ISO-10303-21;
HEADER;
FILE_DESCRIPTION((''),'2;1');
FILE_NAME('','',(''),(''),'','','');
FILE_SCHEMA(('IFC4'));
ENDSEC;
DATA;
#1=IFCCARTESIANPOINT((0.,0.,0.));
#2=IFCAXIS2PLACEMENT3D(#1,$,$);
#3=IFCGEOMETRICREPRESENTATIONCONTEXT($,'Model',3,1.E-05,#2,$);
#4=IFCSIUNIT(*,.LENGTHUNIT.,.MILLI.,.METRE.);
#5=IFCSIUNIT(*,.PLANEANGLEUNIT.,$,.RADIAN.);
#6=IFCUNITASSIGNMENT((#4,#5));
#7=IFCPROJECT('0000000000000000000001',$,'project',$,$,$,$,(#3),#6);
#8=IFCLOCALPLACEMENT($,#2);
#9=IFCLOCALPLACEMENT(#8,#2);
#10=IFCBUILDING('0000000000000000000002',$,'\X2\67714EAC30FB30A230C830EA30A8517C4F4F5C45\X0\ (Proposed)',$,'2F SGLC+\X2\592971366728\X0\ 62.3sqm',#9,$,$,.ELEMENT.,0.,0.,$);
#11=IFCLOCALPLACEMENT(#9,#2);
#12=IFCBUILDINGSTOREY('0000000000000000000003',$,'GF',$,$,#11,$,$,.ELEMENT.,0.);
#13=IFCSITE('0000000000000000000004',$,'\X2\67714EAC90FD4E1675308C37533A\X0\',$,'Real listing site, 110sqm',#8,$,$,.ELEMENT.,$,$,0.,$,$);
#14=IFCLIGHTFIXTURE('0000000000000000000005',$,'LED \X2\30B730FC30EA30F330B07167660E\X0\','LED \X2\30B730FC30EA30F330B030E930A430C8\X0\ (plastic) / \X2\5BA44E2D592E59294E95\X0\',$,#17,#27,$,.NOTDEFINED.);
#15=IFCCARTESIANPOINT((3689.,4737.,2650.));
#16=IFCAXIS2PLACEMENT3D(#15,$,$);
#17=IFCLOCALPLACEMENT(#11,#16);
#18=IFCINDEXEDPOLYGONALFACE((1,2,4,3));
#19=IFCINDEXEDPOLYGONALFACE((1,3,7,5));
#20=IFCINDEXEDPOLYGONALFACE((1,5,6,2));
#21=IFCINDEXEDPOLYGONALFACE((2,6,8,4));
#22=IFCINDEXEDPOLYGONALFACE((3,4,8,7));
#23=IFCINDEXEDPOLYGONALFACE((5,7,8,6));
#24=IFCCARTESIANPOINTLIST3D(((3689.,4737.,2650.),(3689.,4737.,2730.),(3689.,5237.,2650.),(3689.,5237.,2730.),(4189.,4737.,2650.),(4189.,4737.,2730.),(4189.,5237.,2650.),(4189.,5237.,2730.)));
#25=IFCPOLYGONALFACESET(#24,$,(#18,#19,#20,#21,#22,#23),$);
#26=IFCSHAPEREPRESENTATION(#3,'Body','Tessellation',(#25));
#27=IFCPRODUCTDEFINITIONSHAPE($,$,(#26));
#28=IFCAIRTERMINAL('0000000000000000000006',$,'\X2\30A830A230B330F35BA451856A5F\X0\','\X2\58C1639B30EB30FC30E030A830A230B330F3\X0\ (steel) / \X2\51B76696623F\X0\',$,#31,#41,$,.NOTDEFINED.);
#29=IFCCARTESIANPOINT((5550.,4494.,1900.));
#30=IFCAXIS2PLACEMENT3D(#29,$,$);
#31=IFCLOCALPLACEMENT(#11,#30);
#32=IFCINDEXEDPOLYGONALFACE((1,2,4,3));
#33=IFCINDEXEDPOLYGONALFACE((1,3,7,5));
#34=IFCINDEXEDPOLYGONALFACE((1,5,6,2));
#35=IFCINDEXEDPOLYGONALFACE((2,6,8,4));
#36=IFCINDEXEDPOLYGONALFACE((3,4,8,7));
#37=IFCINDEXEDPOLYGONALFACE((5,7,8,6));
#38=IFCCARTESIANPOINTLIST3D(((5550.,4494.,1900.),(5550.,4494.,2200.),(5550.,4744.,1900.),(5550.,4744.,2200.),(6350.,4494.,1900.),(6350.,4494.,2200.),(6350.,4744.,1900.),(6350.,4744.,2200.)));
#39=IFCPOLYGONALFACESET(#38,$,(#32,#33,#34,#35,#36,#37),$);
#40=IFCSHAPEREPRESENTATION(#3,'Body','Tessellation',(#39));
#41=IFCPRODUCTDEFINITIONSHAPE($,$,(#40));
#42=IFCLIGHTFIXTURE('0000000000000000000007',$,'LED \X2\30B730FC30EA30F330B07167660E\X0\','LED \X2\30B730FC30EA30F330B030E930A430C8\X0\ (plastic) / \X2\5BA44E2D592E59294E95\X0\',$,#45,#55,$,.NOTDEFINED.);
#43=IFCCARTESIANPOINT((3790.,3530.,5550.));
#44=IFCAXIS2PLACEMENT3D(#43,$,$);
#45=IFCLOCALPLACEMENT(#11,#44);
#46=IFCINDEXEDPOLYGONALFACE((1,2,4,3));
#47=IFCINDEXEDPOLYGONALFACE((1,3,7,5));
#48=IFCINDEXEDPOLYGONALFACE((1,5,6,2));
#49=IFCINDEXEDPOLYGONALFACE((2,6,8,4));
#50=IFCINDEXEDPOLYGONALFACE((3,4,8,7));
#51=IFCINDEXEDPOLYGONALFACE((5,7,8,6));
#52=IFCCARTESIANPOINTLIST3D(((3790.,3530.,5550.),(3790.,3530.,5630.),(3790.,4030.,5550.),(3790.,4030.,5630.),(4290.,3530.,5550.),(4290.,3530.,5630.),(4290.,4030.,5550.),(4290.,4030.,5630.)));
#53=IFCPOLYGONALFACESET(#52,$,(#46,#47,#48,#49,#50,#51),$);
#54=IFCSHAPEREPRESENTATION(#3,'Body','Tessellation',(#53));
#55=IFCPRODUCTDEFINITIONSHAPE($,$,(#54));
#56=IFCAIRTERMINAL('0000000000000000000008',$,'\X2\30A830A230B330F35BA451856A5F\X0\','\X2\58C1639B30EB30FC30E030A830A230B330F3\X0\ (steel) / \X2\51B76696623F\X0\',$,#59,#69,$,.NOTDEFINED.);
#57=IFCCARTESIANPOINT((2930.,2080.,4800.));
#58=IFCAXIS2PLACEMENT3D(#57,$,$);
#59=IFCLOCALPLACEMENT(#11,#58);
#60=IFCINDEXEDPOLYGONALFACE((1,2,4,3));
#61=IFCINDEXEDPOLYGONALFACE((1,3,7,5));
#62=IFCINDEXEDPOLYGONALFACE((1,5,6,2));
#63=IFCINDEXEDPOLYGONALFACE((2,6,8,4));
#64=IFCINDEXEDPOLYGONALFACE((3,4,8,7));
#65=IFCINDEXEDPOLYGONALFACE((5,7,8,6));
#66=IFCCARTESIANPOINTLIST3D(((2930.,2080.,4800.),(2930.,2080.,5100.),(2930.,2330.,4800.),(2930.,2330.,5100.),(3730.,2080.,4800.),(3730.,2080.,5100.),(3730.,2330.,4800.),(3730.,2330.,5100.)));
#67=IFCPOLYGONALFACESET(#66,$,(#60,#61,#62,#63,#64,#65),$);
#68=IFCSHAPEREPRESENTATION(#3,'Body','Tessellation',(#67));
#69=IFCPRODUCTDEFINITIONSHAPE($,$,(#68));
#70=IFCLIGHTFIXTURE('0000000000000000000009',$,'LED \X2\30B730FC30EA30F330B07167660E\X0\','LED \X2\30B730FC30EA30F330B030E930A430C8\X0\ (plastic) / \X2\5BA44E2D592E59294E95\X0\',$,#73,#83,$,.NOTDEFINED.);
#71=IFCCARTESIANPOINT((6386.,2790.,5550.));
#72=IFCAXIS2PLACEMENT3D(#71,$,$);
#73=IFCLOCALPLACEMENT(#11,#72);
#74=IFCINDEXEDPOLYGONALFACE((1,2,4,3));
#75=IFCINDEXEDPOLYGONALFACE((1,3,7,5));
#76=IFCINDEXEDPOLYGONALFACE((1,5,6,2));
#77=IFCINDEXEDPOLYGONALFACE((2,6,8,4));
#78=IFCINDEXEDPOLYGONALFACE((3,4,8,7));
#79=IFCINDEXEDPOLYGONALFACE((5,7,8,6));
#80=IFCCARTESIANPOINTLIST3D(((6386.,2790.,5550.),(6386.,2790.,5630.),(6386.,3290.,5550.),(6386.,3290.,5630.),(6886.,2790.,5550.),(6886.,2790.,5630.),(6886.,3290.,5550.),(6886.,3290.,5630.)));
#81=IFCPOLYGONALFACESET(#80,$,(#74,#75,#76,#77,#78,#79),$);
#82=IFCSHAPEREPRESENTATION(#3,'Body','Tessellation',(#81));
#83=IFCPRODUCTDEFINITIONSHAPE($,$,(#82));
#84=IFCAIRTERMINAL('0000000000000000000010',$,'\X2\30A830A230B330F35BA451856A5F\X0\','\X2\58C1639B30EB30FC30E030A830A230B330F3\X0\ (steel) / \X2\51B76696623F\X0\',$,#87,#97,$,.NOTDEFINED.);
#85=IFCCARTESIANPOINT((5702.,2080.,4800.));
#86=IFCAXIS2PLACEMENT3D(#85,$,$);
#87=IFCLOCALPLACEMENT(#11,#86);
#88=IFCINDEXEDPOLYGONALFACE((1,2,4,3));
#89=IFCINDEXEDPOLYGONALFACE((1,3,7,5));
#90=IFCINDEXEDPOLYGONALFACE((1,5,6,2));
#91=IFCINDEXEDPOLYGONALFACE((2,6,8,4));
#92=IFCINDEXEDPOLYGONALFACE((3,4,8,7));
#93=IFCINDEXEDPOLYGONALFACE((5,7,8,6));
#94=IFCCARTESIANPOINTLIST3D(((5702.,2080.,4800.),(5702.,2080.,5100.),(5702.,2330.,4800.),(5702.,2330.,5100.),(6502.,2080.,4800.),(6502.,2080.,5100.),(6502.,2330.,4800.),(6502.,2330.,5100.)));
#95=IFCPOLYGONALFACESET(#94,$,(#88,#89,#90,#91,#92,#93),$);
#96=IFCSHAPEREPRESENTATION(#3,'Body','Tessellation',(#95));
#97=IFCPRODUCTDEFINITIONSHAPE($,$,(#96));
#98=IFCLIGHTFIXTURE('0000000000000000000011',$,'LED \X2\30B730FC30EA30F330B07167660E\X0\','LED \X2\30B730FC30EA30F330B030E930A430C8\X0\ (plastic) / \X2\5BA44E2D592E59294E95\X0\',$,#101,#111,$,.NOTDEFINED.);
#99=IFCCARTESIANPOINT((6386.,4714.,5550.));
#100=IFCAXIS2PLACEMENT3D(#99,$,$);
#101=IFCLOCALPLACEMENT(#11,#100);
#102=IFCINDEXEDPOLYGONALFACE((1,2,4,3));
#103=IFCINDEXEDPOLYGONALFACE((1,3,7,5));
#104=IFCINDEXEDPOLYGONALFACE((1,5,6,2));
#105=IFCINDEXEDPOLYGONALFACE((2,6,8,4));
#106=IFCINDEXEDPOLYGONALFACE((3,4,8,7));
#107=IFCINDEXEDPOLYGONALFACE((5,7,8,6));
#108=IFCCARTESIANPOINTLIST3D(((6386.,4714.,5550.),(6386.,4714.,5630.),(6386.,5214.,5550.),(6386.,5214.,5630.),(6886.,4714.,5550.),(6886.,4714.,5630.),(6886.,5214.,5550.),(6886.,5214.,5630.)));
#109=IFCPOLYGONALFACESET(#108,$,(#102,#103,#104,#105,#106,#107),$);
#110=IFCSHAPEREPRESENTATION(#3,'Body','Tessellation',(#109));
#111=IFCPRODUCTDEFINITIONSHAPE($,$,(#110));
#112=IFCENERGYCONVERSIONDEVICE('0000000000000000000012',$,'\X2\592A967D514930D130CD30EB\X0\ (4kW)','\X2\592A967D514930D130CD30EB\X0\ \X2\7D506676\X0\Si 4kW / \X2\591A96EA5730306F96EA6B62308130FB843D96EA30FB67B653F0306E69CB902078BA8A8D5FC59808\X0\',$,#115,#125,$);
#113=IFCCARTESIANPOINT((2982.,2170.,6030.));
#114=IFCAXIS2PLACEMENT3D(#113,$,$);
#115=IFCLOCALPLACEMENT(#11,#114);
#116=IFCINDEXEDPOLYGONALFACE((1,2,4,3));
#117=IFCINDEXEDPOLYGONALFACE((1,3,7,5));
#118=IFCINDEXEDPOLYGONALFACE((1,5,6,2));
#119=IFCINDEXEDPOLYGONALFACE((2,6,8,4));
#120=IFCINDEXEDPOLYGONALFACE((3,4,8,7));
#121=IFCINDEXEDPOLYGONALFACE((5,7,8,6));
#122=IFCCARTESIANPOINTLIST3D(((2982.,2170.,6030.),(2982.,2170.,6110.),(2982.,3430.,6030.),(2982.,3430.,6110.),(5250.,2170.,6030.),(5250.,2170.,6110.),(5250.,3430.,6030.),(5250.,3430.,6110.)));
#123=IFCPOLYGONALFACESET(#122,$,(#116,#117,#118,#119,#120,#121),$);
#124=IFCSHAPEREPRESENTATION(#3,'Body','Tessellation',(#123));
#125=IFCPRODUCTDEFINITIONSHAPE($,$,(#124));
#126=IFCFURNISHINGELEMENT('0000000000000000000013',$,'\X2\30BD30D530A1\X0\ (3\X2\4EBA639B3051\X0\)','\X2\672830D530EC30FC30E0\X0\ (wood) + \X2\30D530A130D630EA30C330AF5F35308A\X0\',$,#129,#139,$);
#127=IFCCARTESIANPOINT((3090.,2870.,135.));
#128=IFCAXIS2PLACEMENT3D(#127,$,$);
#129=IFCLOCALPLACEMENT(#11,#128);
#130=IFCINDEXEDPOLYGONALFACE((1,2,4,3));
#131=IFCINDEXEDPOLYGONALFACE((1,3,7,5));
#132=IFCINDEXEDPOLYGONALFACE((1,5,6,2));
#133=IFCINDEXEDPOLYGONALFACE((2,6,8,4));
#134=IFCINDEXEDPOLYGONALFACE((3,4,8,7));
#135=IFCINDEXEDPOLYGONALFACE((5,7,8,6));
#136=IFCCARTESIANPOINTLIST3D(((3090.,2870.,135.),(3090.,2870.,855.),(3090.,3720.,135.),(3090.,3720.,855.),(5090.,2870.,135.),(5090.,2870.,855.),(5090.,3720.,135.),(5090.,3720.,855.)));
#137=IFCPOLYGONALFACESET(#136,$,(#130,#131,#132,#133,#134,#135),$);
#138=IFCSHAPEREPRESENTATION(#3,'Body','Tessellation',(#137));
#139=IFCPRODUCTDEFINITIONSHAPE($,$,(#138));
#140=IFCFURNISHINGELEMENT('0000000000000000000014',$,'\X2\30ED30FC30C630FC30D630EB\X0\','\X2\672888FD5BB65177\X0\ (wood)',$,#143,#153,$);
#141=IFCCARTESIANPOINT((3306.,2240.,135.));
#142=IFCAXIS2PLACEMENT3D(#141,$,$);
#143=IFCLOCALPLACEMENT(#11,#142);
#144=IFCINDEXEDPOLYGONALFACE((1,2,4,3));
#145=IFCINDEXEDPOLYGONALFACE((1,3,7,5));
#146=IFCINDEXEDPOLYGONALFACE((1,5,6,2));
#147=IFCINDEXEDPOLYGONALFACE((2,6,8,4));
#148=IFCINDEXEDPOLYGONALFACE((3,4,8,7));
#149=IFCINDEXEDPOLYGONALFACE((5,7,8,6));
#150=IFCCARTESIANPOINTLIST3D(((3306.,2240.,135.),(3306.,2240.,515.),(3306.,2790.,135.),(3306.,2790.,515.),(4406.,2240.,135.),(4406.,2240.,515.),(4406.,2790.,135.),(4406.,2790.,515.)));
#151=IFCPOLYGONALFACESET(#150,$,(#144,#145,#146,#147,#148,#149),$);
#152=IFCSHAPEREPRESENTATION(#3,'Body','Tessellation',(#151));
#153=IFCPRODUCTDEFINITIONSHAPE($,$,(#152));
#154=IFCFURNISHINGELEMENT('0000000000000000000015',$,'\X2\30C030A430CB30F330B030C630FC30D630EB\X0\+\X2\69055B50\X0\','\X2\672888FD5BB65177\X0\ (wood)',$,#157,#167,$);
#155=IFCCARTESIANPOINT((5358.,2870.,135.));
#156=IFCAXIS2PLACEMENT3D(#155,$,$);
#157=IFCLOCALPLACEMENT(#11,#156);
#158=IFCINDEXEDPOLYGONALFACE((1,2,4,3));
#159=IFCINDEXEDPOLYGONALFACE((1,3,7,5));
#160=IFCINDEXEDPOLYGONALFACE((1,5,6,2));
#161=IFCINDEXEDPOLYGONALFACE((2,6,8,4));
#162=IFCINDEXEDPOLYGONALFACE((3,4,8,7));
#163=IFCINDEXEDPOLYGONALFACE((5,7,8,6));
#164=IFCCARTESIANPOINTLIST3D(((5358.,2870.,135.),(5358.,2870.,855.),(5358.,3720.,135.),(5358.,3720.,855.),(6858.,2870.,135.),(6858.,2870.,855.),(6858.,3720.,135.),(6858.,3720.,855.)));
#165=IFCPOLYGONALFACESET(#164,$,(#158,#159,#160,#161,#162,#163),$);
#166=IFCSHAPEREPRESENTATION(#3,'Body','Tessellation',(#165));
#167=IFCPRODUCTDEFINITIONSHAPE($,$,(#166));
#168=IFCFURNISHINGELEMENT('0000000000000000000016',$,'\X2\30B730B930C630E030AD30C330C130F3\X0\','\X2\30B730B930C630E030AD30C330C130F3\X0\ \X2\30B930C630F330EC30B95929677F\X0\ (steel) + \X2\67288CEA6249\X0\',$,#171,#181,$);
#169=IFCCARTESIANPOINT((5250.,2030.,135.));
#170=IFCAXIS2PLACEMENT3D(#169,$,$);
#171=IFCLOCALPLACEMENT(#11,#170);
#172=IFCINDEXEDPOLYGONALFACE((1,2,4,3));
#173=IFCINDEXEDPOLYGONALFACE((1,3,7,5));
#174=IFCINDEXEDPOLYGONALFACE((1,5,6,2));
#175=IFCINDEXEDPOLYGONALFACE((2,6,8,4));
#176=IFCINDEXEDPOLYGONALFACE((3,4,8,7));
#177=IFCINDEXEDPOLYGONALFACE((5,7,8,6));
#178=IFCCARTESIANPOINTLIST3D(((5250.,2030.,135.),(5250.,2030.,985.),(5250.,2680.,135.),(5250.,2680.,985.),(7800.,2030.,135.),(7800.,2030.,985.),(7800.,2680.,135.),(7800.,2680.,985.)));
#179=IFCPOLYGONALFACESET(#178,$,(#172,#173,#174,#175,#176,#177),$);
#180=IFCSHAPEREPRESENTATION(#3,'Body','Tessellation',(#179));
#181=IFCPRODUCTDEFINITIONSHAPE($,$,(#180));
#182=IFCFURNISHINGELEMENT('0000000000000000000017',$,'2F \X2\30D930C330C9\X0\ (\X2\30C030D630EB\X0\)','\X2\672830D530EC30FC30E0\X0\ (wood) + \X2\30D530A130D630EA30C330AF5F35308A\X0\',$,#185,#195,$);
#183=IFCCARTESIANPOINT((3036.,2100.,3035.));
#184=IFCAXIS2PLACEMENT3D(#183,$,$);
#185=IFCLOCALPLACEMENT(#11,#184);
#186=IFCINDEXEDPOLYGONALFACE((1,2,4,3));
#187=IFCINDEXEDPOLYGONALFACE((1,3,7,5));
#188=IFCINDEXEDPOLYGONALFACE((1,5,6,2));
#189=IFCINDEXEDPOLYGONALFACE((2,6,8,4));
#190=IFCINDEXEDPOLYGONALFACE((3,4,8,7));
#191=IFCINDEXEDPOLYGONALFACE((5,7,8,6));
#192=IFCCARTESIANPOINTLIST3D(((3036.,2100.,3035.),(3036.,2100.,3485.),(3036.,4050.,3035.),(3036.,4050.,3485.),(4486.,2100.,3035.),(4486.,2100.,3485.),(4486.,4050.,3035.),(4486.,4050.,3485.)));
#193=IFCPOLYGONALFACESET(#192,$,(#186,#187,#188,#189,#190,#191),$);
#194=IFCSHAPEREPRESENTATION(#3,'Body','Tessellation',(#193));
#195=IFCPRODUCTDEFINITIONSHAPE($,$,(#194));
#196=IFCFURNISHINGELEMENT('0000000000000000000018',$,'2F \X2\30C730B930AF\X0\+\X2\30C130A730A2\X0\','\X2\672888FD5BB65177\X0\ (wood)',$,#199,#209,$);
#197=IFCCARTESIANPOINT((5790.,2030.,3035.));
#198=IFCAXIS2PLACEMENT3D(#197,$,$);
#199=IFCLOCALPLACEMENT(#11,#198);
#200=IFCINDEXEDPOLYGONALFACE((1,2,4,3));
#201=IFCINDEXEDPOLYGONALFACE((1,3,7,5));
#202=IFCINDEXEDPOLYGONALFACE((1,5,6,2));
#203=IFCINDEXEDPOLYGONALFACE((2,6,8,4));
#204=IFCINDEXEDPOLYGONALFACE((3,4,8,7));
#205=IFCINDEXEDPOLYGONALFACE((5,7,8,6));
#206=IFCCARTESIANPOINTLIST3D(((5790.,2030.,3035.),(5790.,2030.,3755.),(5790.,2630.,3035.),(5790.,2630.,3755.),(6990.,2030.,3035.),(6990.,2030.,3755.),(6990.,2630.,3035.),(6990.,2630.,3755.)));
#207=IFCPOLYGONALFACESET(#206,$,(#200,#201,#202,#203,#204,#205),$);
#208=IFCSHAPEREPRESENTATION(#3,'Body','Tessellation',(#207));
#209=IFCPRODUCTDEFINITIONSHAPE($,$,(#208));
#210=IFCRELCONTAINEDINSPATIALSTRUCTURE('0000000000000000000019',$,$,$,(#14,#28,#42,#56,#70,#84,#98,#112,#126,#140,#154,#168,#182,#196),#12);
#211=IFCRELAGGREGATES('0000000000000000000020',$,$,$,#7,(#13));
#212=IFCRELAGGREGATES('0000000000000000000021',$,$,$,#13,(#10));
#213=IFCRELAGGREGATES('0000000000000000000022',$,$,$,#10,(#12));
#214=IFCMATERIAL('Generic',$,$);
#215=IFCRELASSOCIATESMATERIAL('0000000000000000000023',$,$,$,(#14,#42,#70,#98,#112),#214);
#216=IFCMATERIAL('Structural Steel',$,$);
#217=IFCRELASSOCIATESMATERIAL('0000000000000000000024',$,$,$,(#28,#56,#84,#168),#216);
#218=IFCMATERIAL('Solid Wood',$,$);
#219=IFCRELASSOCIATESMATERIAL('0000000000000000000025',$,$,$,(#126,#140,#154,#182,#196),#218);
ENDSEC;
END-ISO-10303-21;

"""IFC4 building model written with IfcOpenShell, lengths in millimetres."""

from ifc_helpers import new_model, si_unit, frame, frame_2d, origin, place, context, project, spatial, rectangle, extrude, material, element, save


model = new_model("IFC4")

# Units and contexts
model_context = context("Model", 3, precision=1e-05, world=origin())
ifc_project = project(units=[si_unit("LENGTHUNIT", "METRE", prefix="MILLI"), si_unit("PLANEANGLEUNIT", "RADIAN")], contexts=[model_context])

# Site, building, storey
site_placement = place(None, origin())
site = spatial("IfcSite", under=ifc_project, at=site_placement, Name="東京都世田谷区", ObjectType="Real listing site, 110sqm", CompositionType="ELEMENT", RefElevation=0.0)
building_placement = place(site_placement, origin())
building = spatial("IfcBuilding", under=site, at=building_placement, Name="東京・アトリエ兼住居 (Proposed)", ObjectType="2F SGLC+天然木 62.3sqm", CompositionType="ELEMENT", ElevationOfRefHeight=0.0, ElevationOfTerrain=0.0)
storey_placement = place(building_placement, origin())
storey = spatial("IfcBuildingStorey", under=building, at=storey_placement, Name="GF", CompositionType="ELEMENT", Elevation=0.0)

# Shared definitions
ifc_material_1 = material(Name="Solid Wood")

# Shared definitions
ifc_material_2 = material(Name="Structural Steel")

# Shared definitions
ifc_material_3 = material(Name="Generic")

# Light fixture
light_fixture_1_placement = place(storey_placement, frame((3689.0, 4737.0, 2650.0)))
element("IfcLightFixture", 1, at=light_fixture_1_placement, inside=storey, material=ifc_material_3, Name="LED シーリング照明", Description="LED シーリングライト (plastic) / 室中央天井", PredefinedType="NOTDEFINED", context=model_context, shape_type="SweptSolid", body=[
    extrude(rectangle(XDim=500.0, YDim=500.0, at=frame_2d((250.0, 250.0))), frame((3689.0, 4737.0, 2650.0)), (0.0, 0.0, 1.0), 80.0),
])

# Air terminal
air_terminal_1_placement = place(storey_placement, frame((5550.0, 4494.0, 1900.0)))
element("IfcAirTerminal", 2, at=air_terminal_1_placement, inside=storey, material=ifc_material_2, Name="エアコン室内機", Description="壁掛ルームエアコン (steel) / 冷暖房", PredefinedType="NOTDEFINED", context=model_context, shape_type="SweptSolid", body=[
    extrude(rectangle(XDim=800.0, YDim=250.0, at=frame_2d((400.0, 125.0))), frame((5550.0, 4494.0, 1900.0)), (0.0, 0.0, 1.0), 300.0),
])

# Light fixture
light_fixture_2_placement = place(storey_placement, frame((3790.0, 3530.0, 5550.0)))
element("IfcLightFixture", 3, at=light_fixture_2_placement, inside=storey, material=ifc_material_3, Name="LED シーリング照明", Description="LED シーリングライト (plastic) / 室中央天井", PredefinedType="NOTDEFINED", context=model_context, shape_type="SweptSolid", body=[
    extrude(rectangle(XDim=500.0, YDim=500.0, at=frame_2d((250.0, 250.0))), frame((3790.0, 3530.0, 5550.0)), (0.0, 0.0, 1.0), 80.0),
])

# Air terminal
air_terminal_2_placement = place(storey_placement, frame((2930.0, 2080.0, 4800.0)))
element("IfcAirTerminal", 4, at=air_terminal_2_placement, inside=storey, material=ifc_material_2, Name="エアコン室内機", Description="壁掛ルームエアコン (steel) / 冷暖房", PredefinedType="NOTDEFINED", context=model_context, shape_type="SweptSolid", body=[
    extrude(rectangle(XDim=800.0, YDim=250.0, at=frame_2d((400.0, 125.0))), frame((2930.0, 2080.0, 4800.0)), (0.0, 0.0, 1.0), 300.0),
])

# Light fixture
light_fixture_3_placement = place(storey_placement, frame((6386.0, 2790.0, 5550.0)))
element("IfcLightFixture", 5, at=light_fixture_3_placement, inside=storey, material=ifc_material_3, Name="LED シーリング照明", Description="LED シーリングライト (plastic) / 室中央天井", PredefinedType="NOTDEFINED", context=model_context, shape_type="SweptSolid", body=[
    extrude(rectangle(XDim=500.0, YDim=500.0, at=frame_2d((250.0, 250.0))), frame((6386.0, 2790.0, 5550.0)), (0.0, 0.0, 1.0), 80.0),
])

# Air terminal
air_terminal_3_placement = place(storey_placement, frame((5702.0, 2080.0, 4800.0)))
element("IfcAirTerminal", 6, at=air_terminal_3_placement, inside=storey, material=ifc_material_2, Name="エアコン室内機", Description="壁掛ルームエアコン (steel) / 冷暖房", PredefinedType="NOTDEFINED", context=model_context, shape_type="SweptSolid", body=[
    extrude(rectangle(XDim=800.0, YDim=250.0, at=frame_2d((400.0, 125.0))), frame((5702.0, 2080.0, 4800.0)), (0.0, 0.0, 1.0), 300.0),
])

# Light fixture
light_fixture_4_placement = place(storey_placement, frame((6386.0, 4714.0, 5550.0)))
element("IfcLightFixture", 7, at=light_fixture_4_placement, inside=storey, material=ifc_material_3, Name="LED シーリング照明", Description="LED シーリングライト (plastic) / 室中央天井", PredefinedType="NOTDEFINED", context=model_context, shape_type="SweptSolid", body=[
    extrude(rectangle(XDim=500.0, YDim=500.0, at=frame_2d((250.0, 250.0))), frame((6386.0, 4714.0, 5550.0)), (0.0, 0.0, 1.0), 80.0),
])

# Energy conversion device
energy_conversion_device_placement = place(storey_placement, frame((2982.0, 2170.0, 6030.0)))
element("IfcEnergyConversionDevice", 8, at=energy_conversion_device_placement, inside=storey, material=ifc_material_3, Name="太陽光パネル (4kW)", Description="太陽光パネル 結晶Si 4kW / 多雪地は雪止め・落雪・架台の構造確認必須", context=model_context, shape_type="SweptSolid", body=[
    extrude(rectangle(XDim=2268.0, YDim=1260.0, at=frame_2d((1134.0, 630.0))), frame((2982.0, 2170.0, 6030.0)), (0.0, 0.0, 1.0), 80.0),
])

# Furnishing elements
furnishing_1_placement = place(storey_placement, frame((3090.0, 2870.0, 135.0)))
element("IfcFurnishingElement", 9, at=furnishing_1_placement, inside=storey, material=ifc_material_1, Name="ソファ (3人掛け)", Description="木フレーム (wood) + ファブリック張り", context=model_context, shape_type="SweptSolid", body=[
    extrude(rectangle(XDim=2000.0, YDim=850.0, at=frame_2d((1000.0, 425.0))), frame((3090.0, 2870.0, 135.0)), (0.0, 0.0, 1.0), 720.0),
])
furnishing_2_placement = place(storey_placement, frame((3306.0, 2240.0, 135.0)))
element("IfcFurnishingElement", 10, at=furnishing_2_placement, inside=storey, material=ifc_material_1, Name="ローテーブル", Description="木製家具 (wood)", context=model_context, shape_type="SweptSolid", body=[
    extrude(rectangle(XDim=1100.0, YDim=550.0, at=frame_2d((550.0, 275.0))), frame((3306.0, 2240.0, 135.0)), (0.0, 0.0, 1.0), 380.0),
])
furnishing_3_placement = place(storey_placement, frame((5358.0, 2870.0, 135.0)))
element("IfcFurnishingElement", 11, at=furnishing_3_placement, inside=storey, material=ifc_material_1, Name="ダイニングテーブル+椅子", Description="木製家具 (wood)", context=model_context, shape_type="SweptSolid", body=[
    extrude(rectangle(XDim=1500.0, YDim=850.0, at=frame_2d((750.0, 425.0))), frame((5358.0, 2870.0, 135.0)), (0.0, 0.0, 1.0), 720.0),
])
furnishing_4_placement = place(storey_placement, frame((5250.0, 2030.0, 135.0)))
element("IfcFurnishingElement", 12, at=furnishing_4_placement, inside=storey, material=ifc_material_2, Name="システムキッチン", Description="システムキッチン ステンレス天板 (steel) + 木質扉", context=model_context, shape_type="SweptSolid", body=[
    extrude(rectangle(XDim=2550.0, YDim=650.0, at=frame_2d((1275.0, 325.0))), frame((5250.0, 2030.0, 135.0)), (0.0, 0.0, 1.0), 850.0),
])
furnishing_5_placement = place(storey_placement, frame((3036.0, 2100.0, 3035.0)))
element("IfcFurnishingElement", 13, at=furnishing_5_placement, inside=storey, material=ifc_material_1, Name="2F ベッド (ダブル)", Description="木フレーム (wood) + ファブリック張り", context=model_context, shape_type="SweptSolid", body=[
    extrude(rectangle(XDim=1450.0, YDim=1950.0, at=frame_2d((725.0, 975.0))), frame((3036.0, 2100.0, 3035.0)), (0.0, 0.0, 1.0), 450.0),
])
furnishing_6_placement = place(storey_placement, frame((5790.0, 2030.0, 3035.0)))
element("IfcFurnishingElement", 14, at=furnishing_6_placement, inside=storey, material=ifc_material_1, Name="2F デスク+チェア", Description="木製家具 (wood)", context=model_context, shape_type="SweptSolid", body=[
    extrude(rectangle(XDim=1200.0, YDim=600.0, at=frame_2d((600.0, 300.0))), frame((5790.0, 2030.0, 3035.0)), (0.0, 0.0, 1.0), 720.0),
])

save(model, "model.ifc")
